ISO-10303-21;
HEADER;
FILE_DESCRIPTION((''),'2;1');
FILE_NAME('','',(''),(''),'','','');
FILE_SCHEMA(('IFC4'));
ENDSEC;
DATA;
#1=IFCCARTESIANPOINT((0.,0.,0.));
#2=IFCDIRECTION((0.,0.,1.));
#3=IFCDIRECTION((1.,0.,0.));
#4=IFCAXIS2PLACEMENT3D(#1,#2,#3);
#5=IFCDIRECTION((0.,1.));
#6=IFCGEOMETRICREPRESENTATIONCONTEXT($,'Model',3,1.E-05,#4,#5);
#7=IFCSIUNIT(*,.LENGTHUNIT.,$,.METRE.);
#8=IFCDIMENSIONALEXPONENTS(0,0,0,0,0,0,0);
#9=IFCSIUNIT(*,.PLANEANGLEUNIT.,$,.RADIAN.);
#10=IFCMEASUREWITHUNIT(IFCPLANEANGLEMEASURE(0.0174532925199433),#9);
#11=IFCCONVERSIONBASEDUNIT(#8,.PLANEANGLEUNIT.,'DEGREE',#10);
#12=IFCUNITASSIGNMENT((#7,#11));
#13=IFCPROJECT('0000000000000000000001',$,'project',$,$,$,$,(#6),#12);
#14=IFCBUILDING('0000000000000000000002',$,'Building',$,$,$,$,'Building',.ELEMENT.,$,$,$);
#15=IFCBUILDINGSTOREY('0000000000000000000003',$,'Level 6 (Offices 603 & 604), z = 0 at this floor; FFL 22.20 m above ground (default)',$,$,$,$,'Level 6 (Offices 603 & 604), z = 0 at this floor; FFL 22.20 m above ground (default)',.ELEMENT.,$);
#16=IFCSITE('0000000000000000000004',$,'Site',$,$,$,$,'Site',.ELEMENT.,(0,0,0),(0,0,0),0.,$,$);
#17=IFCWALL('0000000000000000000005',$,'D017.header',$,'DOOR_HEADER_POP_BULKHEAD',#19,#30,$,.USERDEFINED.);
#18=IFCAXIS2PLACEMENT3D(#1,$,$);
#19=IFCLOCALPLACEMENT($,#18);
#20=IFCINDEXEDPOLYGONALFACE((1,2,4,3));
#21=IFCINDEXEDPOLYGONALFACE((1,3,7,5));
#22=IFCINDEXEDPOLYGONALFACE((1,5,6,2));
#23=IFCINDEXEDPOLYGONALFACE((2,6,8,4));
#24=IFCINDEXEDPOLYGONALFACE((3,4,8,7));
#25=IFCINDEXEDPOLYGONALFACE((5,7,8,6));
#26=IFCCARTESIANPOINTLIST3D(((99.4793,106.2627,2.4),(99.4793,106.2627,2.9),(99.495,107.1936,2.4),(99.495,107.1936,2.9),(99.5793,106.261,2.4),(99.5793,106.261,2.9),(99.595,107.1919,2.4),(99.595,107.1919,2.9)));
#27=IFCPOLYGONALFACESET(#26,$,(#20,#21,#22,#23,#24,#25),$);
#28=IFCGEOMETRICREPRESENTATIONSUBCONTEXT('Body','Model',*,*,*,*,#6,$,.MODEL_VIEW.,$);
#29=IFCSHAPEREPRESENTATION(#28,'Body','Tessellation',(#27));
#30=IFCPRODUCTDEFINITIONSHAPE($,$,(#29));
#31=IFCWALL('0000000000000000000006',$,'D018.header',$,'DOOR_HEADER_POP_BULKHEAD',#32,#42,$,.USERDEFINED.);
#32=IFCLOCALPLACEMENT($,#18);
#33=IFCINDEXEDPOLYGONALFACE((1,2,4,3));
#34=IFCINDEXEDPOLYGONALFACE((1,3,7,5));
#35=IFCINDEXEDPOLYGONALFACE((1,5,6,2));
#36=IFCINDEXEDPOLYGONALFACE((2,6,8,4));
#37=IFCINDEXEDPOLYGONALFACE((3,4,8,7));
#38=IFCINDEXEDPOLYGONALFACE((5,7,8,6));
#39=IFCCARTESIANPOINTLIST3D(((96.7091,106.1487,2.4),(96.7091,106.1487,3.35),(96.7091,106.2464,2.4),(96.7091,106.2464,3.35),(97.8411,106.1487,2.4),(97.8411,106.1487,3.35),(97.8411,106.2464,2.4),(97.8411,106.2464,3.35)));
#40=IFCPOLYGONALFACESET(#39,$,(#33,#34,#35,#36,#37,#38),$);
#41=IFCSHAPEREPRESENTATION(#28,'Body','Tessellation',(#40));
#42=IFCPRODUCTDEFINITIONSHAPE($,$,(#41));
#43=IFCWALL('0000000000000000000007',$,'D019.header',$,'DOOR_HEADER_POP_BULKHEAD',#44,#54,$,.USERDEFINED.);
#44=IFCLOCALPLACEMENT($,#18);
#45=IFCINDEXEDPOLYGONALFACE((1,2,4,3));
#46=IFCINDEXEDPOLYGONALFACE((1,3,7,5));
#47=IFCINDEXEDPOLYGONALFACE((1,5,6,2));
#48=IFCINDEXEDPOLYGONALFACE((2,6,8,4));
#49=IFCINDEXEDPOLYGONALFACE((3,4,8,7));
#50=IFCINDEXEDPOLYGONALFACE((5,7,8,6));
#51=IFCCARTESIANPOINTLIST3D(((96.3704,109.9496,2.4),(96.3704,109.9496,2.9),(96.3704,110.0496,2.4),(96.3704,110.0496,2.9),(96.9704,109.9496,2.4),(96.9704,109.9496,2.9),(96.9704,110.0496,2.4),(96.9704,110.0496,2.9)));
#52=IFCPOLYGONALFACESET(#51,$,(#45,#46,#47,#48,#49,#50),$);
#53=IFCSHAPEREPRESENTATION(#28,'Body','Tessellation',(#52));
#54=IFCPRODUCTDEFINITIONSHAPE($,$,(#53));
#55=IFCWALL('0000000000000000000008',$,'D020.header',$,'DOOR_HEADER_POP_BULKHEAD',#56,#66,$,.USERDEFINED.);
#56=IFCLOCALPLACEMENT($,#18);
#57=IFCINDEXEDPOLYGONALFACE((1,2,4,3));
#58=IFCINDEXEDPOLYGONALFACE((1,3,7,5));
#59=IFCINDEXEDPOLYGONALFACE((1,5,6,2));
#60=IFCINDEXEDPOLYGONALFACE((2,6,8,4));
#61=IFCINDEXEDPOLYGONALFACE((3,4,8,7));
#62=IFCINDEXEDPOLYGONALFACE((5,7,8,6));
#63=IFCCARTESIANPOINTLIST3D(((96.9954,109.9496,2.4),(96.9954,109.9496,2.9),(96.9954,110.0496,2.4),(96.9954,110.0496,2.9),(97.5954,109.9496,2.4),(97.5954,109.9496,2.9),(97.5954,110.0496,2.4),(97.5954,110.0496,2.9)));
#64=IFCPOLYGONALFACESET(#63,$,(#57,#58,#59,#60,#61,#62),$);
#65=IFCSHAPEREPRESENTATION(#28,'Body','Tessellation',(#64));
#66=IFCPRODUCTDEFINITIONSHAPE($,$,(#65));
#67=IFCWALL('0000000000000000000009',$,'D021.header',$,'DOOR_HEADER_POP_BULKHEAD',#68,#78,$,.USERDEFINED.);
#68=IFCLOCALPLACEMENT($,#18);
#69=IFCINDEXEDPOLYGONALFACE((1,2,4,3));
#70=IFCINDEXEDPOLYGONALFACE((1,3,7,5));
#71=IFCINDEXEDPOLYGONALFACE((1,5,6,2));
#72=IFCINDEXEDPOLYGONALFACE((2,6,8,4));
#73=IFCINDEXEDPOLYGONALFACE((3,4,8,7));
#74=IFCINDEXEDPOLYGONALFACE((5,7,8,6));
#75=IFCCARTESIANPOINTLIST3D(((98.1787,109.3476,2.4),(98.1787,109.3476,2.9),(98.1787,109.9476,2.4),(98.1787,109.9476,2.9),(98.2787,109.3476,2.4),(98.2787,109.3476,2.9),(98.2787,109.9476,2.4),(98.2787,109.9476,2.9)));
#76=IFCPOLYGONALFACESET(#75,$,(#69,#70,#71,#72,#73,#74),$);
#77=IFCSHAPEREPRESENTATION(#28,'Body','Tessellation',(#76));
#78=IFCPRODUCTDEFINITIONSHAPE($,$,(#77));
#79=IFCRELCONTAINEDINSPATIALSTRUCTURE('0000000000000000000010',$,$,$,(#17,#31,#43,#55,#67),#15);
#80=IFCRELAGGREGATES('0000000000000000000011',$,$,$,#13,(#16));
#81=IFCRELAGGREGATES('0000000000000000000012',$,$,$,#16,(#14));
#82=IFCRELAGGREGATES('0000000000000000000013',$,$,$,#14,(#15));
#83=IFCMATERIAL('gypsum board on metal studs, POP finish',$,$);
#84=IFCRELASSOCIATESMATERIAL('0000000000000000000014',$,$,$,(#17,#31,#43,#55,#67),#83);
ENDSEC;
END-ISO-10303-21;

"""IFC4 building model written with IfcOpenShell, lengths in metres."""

from ifc_helpers import new_model, entity, si_unit, converted_unit, direction, frame, frame_2d, origin_with_axes, origin_2d_with_axis, place, context, subcontext, project, spatial, rectangle, extrude, material, element, save


model = new_model("IFC4")

# Units and contexts
model_context = context("Model", 3, precision=1e-05, world=origin_with_axes(), true_north=direction((0.0, 1.0)))
body_context = subcontext(model_context, "Body", "Model", "MODEL_VIEW")
ifc_project = project(units=[si_unit("LENGTHUNIT", "METRE"), converted_unit("PLANEANGLEUNIT", "DEGREE", entity("IfcPlaneAngleMeasure", 0.0174532925199433), si_unit("PLANEANGLEUNIT", "RADIAN"), dimensions=[0, 0, 0, 0, 0, 0, 0])], contexts=[model_context])

# Site, building, storey
site = spatial("IfcSite", under=ifc_project, Name="Site", LongName="Site", CompositionType="ELEMENT", RefLatitude=(0, 0, 0), RefLongitude=(0, 0, 0), RefElevation=0.0)
building = spatial("IfcBuilding", under=site, Name="Building", LongName="Building", CompositionType="ELEMENT")
storey = spatial("IfcBuildingStorey", under=building, Name="Level 6 (Offices 603 & 604), z = 0 at this floor; FFL 22.20 m above ground (default)", LongName="Level 6 (Offices 603 & 604), z = 0 at this floor; FFL 22.20 m above ground (default)", CompositionType="ELEMENT")

# Shared definitions
placement = place(None, origin_with_axes())

# Walls
ifc_material_1 = material(Name="gypsum board on metal studs, POP finish")
element("IfcWall", 1, at=placement, inside=storey, material=ifc_material_1, Name="D017.header", ObjectType="DOOR_HEADER_POP_BULKHEAD", PredefinedType="USERDEFINED", context=body_context, shape_type="SweptSolid", body=[
    extrude(rectangle(XDim=0.931, YDim=0.1, at=frame_2d((0.0, 0.0), x_axis=(0.016872, 0.999858))), frame((99.5371, 106.7273, 2.4), z_axis=(0.0, 0.0, 1.0), x_axis=(1.0, 0.0, 0.0)), (0.0, 0.0, 1.0), 0.5),
])
element("IfcWall", 2, at=placement, inside=storey, material=ifc_material_1, Name="D018.header", ObjectType="DOOR_HEADER_POP_BULKHEAD", PredefinedType="USERDEFINED", context=body_context, shape_type="SweptSolid", body=[
    extrude(rectangle(XDim=1.132, YDim=0.0977, at=frame_2d((0.0, 0.0), x_axis=(1.0, 0.0))), frame((97.2751, 106.1975, 2.4), z_axis=(0.0, 0.0, 1.0), x_axis=(1.0, 0.0, 0.0)), (0.0, 0.0, 1.0), 0.95),
])
element("IfcWall", 3, at=placement, inside=storey, material=ifc_material_1, Name="D019.header", ObjectType="DOOR_HEADER_POP_BULKHEAD", PredefinedType="USERDEFINED", context=body_context, shape_type="SweptSolid", body=[
    extrude(rectangle(XDim=0.6, YDim=0.1, at=frame_2d((0.0, 0.0), x_axis=(1.0, 0.0))), frame((96.6704, 109.9996, 2.4), z_axis=(0.0, 0.0, 1.0), x_axis=(1.0, 0.0, 0.0)), (0.0, 0.0, 1.0), 0.5),
])
element("IfcWall", 4, at=placement, inside=storey, material=ifc_material_1, Name="D020.header", ObjectType="DOOR_HEADER_POP_BULKHEAD", PredefinedType="USERDEFINED", context=body_context, shape_type="SweptSolid", body=[
    extrude(rectangle(XDim=0.6, YDim=0.1, at=origin_2d_with_axis()), frame((97.2954, 109.9996, 2.4), z_axis=(0.0, 0.0, 1.0), x_axis=(1.0, 0.0, 0.0)), (0.0, 0.0, 1.0), 0.5),
])
element("IfcWall", 5, at=placement, inside=storey, material=ifc_material_1, Name="D021.header", ObjectType="DOOR_HEADER_POP_BULKHEAD", PredefinedType="USERDEFINED", context=body_context, shape_type="SweptSolid", body=[
    extrude(rectangle(XDim=0.6, YDim=0.1, at=frame_2d((0.0, 0.0), x_axis=(0.0, 1.0))), frame((98.2287, 109.6476, 2.4), z_axis=(0.0, 0.0, 1.0), x_axis=(1.0, 0.0, 0.0)), (0.0, 0.0, 1.0), 0.5),
])

save(model, "model.ifc")
